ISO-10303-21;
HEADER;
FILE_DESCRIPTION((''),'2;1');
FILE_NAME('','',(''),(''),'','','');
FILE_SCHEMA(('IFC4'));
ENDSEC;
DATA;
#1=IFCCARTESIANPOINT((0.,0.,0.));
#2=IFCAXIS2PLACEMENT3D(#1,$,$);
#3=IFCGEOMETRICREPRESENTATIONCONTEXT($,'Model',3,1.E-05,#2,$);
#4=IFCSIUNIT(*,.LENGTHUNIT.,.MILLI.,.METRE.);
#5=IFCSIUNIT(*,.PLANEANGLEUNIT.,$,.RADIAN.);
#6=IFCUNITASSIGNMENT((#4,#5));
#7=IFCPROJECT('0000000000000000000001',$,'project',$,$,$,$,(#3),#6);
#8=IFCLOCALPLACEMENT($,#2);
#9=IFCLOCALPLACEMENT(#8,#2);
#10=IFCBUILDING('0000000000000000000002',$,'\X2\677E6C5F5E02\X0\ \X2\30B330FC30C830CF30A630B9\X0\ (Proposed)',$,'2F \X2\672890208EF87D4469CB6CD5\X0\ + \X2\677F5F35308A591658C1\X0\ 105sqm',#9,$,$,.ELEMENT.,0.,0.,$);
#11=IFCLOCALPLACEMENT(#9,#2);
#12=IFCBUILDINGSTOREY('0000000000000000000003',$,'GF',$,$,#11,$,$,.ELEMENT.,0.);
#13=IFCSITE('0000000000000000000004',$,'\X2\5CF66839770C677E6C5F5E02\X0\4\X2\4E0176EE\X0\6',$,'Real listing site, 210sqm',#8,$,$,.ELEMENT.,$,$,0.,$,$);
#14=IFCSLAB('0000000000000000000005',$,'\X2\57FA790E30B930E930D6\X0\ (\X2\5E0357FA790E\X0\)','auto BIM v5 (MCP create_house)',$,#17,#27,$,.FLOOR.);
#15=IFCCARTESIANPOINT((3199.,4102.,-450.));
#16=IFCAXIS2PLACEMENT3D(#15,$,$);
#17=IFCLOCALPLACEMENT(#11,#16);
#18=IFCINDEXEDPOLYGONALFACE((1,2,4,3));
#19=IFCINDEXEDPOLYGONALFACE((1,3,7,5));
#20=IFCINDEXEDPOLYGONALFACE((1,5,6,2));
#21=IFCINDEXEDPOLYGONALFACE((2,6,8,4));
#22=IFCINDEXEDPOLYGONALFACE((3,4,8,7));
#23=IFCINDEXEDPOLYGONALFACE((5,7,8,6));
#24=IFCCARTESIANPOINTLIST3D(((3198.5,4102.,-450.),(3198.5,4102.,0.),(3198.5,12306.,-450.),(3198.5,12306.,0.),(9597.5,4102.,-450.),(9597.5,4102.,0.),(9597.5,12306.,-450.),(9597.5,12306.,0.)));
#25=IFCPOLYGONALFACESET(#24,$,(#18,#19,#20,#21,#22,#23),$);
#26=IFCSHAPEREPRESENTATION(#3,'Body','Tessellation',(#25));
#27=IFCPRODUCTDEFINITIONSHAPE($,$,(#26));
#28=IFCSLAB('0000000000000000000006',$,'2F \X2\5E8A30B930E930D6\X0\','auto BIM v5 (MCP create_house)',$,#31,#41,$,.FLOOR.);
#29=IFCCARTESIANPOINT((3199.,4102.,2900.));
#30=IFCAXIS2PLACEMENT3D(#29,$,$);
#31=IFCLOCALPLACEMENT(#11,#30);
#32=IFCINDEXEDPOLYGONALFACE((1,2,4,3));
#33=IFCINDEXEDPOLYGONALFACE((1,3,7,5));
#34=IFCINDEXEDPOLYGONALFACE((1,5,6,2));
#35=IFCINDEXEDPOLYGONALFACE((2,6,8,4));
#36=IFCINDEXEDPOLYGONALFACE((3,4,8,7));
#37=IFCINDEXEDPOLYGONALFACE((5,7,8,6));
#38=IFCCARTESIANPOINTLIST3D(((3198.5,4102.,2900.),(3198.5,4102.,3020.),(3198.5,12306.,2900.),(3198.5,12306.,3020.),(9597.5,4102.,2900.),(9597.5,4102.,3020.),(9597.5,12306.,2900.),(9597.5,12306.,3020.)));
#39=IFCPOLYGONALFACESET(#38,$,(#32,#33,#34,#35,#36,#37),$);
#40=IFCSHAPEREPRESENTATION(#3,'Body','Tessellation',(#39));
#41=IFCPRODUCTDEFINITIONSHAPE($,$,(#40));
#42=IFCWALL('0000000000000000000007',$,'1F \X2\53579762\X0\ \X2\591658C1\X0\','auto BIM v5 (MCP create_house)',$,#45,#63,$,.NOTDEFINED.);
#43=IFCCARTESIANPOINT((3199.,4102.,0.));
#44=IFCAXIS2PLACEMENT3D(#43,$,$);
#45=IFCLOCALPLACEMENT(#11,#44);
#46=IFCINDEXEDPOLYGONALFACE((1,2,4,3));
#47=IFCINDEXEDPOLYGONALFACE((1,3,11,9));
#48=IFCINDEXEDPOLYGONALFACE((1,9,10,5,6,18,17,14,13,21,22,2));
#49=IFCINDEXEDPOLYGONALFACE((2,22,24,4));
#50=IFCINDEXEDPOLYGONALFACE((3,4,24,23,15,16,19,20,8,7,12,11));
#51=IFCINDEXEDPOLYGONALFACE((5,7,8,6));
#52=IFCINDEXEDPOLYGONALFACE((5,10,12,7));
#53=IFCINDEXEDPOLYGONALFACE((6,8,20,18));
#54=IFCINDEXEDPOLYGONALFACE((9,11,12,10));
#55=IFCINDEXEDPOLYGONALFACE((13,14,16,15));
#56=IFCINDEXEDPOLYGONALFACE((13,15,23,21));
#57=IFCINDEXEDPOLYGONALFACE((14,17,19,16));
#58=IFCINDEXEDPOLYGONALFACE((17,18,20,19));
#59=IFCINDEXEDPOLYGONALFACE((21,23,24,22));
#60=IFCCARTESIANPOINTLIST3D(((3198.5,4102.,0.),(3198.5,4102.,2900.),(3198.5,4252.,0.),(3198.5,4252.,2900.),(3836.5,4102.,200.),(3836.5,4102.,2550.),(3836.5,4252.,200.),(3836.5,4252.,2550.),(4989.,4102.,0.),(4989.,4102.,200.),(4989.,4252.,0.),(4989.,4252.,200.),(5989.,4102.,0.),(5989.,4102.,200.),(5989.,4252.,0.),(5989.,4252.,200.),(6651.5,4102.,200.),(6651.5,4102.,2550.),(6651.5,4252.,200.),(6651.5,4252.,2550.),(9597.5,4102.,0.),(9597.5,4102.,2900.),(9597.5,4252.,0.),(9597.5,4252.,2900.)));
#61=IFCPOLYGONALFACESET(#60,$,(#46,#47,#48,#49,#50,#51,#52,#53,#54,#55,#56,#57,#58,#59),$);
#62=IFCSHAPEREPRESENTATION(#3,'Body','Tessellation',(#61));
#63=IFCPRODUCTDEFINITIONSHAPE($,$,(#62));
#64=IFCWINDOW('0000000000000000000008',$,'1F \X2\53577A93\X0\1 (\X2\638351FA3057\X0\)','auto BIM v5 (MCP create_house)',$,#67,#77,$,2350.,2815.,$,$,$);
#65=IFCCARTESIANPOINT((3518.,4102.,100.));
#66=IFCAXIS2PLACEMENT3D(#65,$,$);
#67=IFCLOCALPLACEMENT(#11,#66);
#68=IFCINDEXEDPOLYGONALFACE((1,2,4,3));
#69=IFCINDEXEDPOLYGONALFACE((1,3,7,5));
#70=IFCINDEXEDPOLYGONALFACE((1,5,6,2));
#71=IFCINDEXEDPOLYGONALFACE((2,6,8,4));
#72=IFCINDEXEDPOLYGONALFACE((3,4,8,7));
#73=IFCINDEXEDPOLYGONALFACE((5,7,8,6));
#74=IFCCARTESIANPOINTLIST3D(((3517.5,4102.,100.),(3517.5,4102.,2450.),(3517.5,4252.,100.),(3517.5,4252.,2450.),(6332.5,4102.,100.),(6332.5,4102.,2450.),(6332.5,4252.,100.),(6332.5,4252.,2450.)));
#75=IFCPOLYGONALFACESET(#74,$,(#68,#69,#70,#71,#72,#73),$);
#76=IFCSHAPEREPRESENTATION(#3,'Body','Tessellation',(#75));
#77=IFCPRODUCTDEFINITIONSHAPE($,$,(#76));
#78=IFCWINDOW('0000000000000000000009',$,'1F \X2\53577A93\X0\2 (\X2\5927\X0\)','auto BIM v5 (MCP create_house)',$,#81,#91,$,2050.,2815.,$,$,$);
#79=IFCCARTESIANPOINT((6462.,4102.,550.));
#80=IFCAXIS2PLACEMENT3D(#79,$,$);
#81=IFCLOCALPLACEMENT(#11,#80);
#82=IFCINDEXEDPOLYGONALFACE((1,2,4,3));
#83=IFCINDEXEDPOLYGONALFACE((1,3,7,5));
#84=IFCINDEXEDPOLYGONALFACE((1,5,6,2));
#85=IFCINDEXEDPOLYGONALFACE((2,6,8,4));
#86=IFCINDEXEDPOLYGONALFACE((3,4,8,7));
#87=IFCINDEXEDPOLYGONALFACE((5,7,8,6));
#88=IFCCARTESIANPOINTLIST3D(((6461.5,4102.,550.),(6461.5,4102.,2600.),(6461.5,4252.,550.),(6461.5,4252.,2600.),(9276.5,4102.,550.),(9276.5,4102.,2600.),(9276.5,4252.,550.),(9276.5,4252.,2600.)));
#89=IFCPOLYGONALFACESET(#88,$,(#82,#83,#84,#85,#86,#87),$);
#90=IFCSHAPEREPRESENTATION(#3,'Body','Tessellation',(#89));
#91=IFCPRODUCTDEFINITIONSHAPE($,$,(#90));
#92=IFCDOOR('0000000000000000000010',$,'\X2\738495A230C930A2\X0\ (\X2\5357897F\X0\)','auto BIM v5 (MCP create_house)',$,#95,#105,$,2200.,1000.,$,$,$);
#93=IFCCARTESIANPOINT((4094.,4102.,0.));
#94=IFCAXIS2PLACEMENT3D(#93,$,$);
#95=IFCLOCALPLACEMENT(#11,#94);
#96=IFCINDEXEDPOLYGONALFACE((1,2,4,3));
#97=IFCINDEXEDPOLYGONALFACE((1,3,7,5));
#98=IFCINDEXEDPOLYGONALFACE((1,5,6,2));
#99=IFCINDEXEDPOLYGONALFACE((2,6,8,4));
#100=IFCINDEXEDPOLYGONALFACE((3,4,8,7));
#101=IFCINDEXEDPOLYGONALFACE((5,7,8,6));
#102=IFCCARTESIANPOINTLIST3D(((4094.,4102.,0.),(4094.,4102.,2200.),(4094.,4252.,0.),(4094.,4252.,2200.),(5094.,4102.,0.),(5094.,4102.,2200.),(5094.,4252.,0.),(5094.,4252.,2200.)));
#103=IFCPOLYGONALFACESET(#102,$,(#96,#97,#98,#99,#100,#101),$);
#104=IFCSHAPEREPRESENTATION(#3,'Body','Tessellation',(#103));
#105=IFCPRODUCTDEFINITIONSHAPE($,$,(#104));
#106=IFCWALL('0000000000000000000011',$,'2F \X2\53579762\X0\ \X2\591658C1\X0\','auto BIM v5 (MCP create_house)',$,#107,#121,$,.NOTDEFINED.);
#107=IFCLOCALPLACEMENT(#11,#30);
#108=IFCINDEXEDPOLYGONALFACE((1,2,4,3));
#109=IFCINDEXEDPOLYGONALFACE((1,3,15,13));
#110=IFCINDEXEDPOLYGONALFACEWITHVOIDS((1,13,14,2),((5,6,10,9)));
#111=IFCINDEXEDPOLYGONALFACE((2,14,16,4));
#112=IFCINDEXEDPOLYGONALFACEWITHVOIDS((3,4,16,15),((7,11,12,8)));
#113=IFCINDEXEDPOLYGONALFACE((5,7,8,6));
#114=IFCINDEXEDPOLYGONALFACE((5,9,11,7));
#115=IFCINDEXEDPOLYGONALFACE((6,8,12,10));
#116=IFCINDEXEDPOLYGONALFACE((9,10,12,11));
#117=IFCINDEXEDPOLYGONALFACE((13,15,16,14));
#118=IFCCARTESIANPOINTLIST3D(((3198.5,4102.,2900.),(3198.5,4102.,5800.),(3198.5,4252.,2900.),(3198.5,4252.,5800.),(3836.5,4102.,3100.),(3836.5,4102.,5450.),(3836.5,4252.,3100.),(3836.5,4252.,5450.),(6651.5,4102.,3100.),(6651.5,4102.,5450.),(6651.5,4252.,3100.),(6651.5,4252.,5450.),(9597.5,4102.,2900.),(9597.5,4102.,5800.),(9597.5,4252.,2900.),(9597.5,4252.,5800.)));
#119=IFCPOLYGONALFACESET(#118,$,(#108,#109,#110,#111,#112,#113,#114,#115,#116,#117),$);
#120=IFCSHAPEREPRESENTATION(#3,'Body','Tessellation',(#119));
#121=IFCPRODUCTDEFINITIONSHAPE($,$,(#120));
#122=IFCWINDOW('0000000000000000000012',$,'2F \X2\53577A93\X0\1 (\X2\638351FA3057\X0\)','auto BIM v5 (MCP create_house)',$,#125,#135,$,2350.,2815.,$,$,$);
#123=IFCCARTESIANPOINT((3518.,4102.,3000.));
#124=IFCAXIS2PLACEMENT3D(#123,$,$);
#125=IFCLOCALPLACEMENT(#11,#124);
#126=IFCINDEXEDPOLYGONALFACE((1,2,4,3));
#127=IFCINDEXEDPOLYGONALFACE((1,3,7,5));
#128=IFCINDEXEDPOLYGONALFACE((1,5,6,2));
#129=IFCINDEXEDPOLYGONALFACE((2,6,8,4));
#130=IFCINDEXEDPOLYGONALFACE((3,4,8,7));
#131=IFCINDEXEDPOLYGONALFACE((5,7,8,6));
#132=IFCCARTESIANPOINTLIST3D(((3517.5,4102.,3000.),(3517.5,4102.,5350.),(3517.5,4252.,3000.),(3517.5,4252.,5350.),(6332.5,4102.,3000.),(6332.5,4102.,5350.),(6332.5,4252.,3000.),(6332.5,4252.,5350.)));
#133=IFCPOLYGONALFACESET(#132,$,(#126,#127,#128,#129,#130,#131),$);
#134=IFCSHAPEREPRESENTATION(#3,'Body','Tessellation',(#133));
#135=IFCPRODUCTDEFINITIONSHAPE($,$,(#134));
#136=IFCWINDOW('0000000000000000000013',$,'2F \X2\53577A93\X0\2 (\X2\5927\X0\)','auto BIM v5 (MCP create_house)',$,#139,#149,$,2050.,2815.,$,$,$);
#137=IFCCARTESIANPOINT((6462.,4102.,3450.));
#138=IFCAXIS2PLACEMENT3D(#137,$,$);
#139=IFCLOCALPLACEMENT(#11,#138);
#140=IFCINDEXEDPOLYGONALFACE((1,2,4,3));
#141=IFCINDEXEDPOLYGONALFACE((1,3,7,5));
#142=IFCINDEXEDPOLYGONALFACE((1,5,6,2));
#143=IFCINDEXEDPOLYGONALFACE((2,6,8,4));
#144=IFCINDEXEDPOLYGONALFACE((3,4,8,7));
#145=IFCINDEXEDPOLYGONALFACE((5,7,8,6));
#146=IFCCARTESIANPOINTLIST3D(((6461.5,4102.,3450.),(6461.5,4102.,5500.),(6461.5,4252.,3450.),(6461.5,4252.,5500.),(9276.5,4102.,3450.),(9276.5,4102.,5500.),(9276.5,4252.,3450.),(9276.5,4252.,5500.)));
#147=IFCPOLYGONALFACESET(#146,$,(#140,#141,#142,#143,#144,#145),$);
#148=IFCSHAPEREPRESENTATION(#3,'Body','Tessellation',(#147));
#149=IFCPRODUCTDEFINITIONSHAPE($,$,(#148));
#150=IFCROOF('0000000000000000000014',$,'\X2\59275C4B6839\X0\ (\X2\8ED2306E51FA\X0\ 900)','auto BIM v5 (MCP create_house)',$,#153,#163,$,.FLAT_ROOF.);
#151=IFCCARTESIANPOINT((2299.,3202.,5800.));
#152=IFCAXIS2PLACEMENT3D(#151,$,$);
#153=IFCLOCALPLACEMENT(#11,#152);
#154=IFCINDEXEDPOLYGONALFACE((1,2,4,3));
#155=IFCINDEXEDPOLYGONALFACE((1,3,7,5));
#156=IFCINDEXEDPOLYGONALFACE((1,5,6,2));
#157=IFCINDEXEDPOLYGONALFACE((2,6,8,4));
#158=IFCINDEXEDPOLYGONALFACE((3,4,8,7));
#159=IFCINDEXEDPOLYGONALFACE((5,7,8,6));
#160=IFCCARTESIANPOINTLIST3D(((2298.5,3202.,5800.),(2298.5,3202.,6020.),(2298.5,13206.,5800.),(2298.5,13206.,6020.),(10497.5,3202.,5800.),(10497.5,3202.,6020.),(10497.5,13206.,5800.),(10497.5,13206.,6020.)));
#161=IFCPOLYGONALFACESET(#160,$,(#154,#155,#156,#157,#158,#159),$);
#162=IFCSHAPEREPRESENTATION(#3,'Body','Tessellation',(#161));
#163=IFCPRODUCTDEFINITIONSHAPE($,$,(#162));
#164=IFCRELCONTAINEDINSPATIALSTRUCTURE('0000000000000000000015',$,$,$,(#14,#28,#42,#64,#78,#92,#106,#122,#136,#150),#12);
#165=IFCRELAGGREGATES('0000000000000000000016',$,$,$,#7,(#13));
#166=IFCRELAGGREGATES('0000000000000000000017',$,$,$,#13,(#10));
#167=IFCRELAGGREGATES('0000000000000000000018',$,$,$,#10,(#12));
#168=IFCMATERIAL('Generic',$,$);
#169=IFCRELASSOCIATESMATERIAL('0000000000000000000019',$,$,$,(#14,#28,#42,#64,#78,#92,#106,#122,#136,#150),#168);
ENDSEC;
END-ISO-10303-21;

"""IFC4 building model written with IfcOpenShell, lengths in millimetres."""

from ifc_helpers import new_model, si_unit, frame, frame_2d, origin, place, context, project, spatial, rectangle, extrude, material, element, fill, save


model = new_model("IFC4")

# Units and contexts
model_context = context("Model", 3, precision=1e-05, world=origin())
ifc_project = project(units=[si_unit("LENGTHUNIT", "METRE", prefix="MILLI"), si_unit("PLANEANGLEUNIT", "RADIAN")], contexts=[model_context])

# Site, building, storey
site_placement = place(None, origin())
site = spatial("IfcSite", under=ifc_project, at=site_placement, Name="島根県松江市4丁目6", ObjectType="Real listing site, 210sqm", CompositionType="ELEMENT", RefElevation=0.0)
building_placement = place(site_placement, origin())
building = spatial("IfcBuilding", under=site, at=building_placement, Name="松江市 コートハウス (Proposed)", ObjectType="2F 木造軸組構法 + 板張り外壁 105sqm", CompositionType="ELEMENT", ElevationOfRefHeight=0.0, ElevationOfTerrain=0.0)
storey_placement = place(building_placement, origin())
storey = spatial("IfcBuildingStorey", under=building, at=storey_placement, Name="GF", CompositionType="ELEMENT", Elevation=0.0)

# Slabs
ifc_material = material(Name="Generic")
slab_1_placement = place(storey_placement, frame((3199.0, 4102.0, -450.0)))
element("IfcSlab", 1, at=slab_1_placement, inside=storey, material=ifc_material, Name="基礎スラブ (布基礎)", Description="auto BIM v5 (MCP create_house)", PredefinedType="FLOOR", context=model_context, shape_type="SweptSolid", body=[
    extrude(rectangle(XDim=6399.0, YDim=8204.0, at=frame_2d((3199.0, 4102.0))), frame((3199.0, 4102.0, -450.0)), (0.0, 0.0, 1.0), 450.0),
])
slab_2_placement = place(storey_placement, frame((3199.0, 4102.0, 2900.0)))
element("IfcSlab", 2, at=slab_2_placement, inside=storey, material=ifc_material, Name="2F 床スラブ", Description="auto BIM v5 (MCP create_house)", PredefinedType="FLOOR", context=model_context, shape_type="SweptSolid", body=[
    extrude(rectangle(XDim=6399.0, YDim=8204.0, at=frame_2d((3199.0, 4102.0))), frame((3199.0, 4102.0, 2900.0)), (0.0, 0.0, 1.0), 120.0),
])

# Wall, openings, windows, door
wall_1_placement = place(storey_placement, frame((3199.0, 4102.0, 0.0)))
wall_1 = element("IfcWall", 3, at=wall_1_placement, inside=storey, material=ifc_material, Name="1F 南面 外壁", Description="auto BIM v5 (MCP create_house)", PredefinedType="NOTDEFINED", context=model_context, shape_type="SweptSolid", body=[
    extrude(rectangle(XDim=6399.0, YDim=150.0, at=frame_2d((3199.0, 75.0))), frame((3199.0, 4102.0, 0.0)), (0.0, 0.0, 1.0), 2900.0),
])
opening_1_placement = place(storey_placement, frame((3518.0, 4102.0, 100.0)))
opening_1 = element("IfcOpeningElement", 4, at=opening_1_placement, cuts=wall_1, PredefinedType="NOTDEFINED", context=model_context, shape_type="SweptSolid", body=[
    extrude(rectangle(XDim=2815.0, YDim=150.0, at=frame_2d((1407.0, 75.0))), frame((3518.0, 4102.0, 100.0)), (0.0, 0.0, 1.0), 2350.0),
])
opening_2_placement = place(storey_placement, frame((6462.0, 4102.0, 550.0)))
opening_2 = element("IfcOpeningElement", 5, at=opening_2_placement, cuts=wall_1, PredefinedType="NOTDEFINED", context=model_context, shape_type="SweptSolid", body=[
    extrude(rectangle(XDim=2815.0, YDim=150.0, at=frame_2d((1407.0, 75.0))), frame((6462.0, 4102.0, 550.0)), (0.0, 0.0, 1.0), 2050.0),
])
opening_3_placement = place(storey_placement, frame((4094.0, 4102.0, 0.0)))
opening_3 = element("IfcOpeningElement", 6, at=opening_3_placement, cuts=wall_1, PredefinedType="NOTDEFINED", context=model_context, shape_type="SweptSolid", body=[
    extrude(rectangle(XDim=1000.0, YDim=150.0, at=frame_2d((500.0, 75.0))), frame((4094.0, 4102.0, 0.0)), (0.0, 0.0, 1.0), 2200.0),
])
window_1_placement = place(storey_placement, frame((3518.0, 4102.0, 100.0)))
window_1 = element("IfcWindow", 7, at=window_1_placement, inside=storey, material=ifc_material, Name="1F 南窓1 (掃出し)", Description="auto BIM v5 (MCP create_house)", OverallHeight=2350.0, OverallWidth=2815.0, context=model_context, shape_type="SweptSolid", body=[
    extrude(rectangle(XDim=2815.0, YDim=150.0, at=frame_2d((1407.0, 75.0))), frame((3518.0, 4102.0, 100.0)), (0.0, 0.0, 1.0), 2350.0),
])
fill(opening_1, window_1)
window_2_placement = place(storey_placement, frame((6462.0, 4102.0, 550.0)))
window_2 = element("IfcWindow", 8, at=window_2_placement, inside=storey, material=ifc_material, Name="1F 南窓2 (大)", Description="auto BIM v5 (MCP create_house)", OverallHeight=2050.0, OverallWidth=2815.0, context=model_context, shape_type="SweptSolid", body=[
    extrude(rectangle(XDim=2815.0, YDim=150.0, at=frame_2d((1407.0, 75.0))), frame((6462.0, 4102.0, 550.0)), (0.0, 0.0, 1.0), 2050.0),
])
fill(opening_2, window_2)
door_placement = place(storey_placement, frame((4094.0, 4102.0, 0.0)))
door = element("IfcDoor", 9, at=door_placement, inside=storey, material=ifc_material, Name="玄関ドア (南西)", Description="auto BIM v5 (MCP create_house)", OverallHeight=2200.0, OverallWidth=1000.0, context=model_context, shape_type="SweptSolid", body=[
    extrude(rectangle(XDim=1000.0, YDim=150.0, at=frame_2d((500.0, 75.0))), frame((4094.0, 4102.0, 0.0)), (0.0, 0.0, 1.0), 2200.0),
])
fill(opening_3, door)

# Wall, openings, windows
wall_2_placement = place(storey_placement, frame((3199.0, 4102.0, 2900.0)))
wall_2 = element("IfcWall", 10, at=wall_2_placement, inside=storey, material=ifc_material, Name="2F 南面 外壁", Description="auto BIM v5 (MCP create_house)", PredefinedType="NOTDEFINED", context=model_context, shape_type="SweptSolid", body=[
    extrude(rectangle(XDim=6399.0, YDim=150.0, at=frame_2d((3199.0, 75.0))), frame((3199.0, 4102.0, 2900.0)), (0.0, 0.0, 1.0), 2900.0),
])
opening_4_placement = place(storey_placement, frame((3518.0, 4102.0, 3000.0)))
opening_4 = element("IfcOpeningElement", 11, at=opening_4_placement, cuts=wall_2, PredefinedType="NOTDEFINED", context=model_context, shape_type="SweptSolid", body=[
    extrude(rectangle(XDim=2815.0, YDim=150.0, at=frame_2d((1407.0, 75.0))), frame((3518.0, 4102.0, 3000.0)), (0.0, 0.0, 1.0), 2350.0),
])
opening_5_placement = place(storey_placement, frame((6462.0, 4102.0, 3450.0)))
opening_5 = element("IfcOpeningElement", 12, at=opening_5_placement, cuts=wall_2, PredefinedType="NOTDEFINED", context=model_context, shape_type="SweptSolid", body=[
    extrude(rectangle(XDim=2815.0, YDim=150.0, at=frame_2d((1407.0, 75.0))), frame((6462.0, 4102.0, 3450.0)), (0.0, 0.0, 1.0), 2050.0),
])
window_3_placement = place(storey_placement, frame((3518.0, 4102.0, 3000.0)))
window_3 = element("IfcWindow", 13, at=window_3_placement, inside=storey, material=ifc_material, Name="2F 南窓1 (掃出し)", Description="auto BIM v5 (MCP create_house)", OverallHeight=2350.0, OverallWidth=2815.0, context=model_context, shape_type="SweptSolid", body=[
    extrude(rectangle(XDim=2815.0, YDim=150.0, at=frame_2d((1407.0, 75.0))), frame((3518.0, 4102.0, 3000.0)), (0.0, 0.0, 1.0), 2350.0),
])
fill(opening_4, window_3)
window_4_placement = place(storey_placement, frame((6462.0, 4102.0, 3450.0)))
window_4 = element("IfcWindow", 14, at=window_4_placement, inside=storey, material=ifc_material, Name="2F 南窓2 (大)", Description="auto BIM v5 (MCP create_house)", OverallHeight=2050.0, OverallWidth=2815.0, context=model_context, shape_type="SweptSolid", body=[
    extrude(rectangle(XDim=2815.0, YDim=150.0, at=frame_2d((1407.0, 75.0))), frame((6462.0, 4102.0, 3450.0)), (0.0, 0.0, 1.0), 2050.0),
])
fill(opening_5, window_4)

# Roof
roof_placement = place(storey_placement, frame((2299.0, 3202.0, 5800.0)))
element("IfcRoof", 15, at=roof_placement, inside=storey, material=ifc_material, Name="大屋根 (軒の出 900)", Description="auto BIM v5 (MCP create_house)", PredefinedType="FLAT_ROOF", context=model_context, shape_type="SweptSolid", body=[
    extrude(rectangle(XDim=8199.0, YDim=10004.0, at=frame_2d((4099.0, 5002.0))), frame((2299.0, 3202.0, 5800.0)), (0.0, 0.0, 1.0), 220.0),
])

save(model, "model.ifc")
